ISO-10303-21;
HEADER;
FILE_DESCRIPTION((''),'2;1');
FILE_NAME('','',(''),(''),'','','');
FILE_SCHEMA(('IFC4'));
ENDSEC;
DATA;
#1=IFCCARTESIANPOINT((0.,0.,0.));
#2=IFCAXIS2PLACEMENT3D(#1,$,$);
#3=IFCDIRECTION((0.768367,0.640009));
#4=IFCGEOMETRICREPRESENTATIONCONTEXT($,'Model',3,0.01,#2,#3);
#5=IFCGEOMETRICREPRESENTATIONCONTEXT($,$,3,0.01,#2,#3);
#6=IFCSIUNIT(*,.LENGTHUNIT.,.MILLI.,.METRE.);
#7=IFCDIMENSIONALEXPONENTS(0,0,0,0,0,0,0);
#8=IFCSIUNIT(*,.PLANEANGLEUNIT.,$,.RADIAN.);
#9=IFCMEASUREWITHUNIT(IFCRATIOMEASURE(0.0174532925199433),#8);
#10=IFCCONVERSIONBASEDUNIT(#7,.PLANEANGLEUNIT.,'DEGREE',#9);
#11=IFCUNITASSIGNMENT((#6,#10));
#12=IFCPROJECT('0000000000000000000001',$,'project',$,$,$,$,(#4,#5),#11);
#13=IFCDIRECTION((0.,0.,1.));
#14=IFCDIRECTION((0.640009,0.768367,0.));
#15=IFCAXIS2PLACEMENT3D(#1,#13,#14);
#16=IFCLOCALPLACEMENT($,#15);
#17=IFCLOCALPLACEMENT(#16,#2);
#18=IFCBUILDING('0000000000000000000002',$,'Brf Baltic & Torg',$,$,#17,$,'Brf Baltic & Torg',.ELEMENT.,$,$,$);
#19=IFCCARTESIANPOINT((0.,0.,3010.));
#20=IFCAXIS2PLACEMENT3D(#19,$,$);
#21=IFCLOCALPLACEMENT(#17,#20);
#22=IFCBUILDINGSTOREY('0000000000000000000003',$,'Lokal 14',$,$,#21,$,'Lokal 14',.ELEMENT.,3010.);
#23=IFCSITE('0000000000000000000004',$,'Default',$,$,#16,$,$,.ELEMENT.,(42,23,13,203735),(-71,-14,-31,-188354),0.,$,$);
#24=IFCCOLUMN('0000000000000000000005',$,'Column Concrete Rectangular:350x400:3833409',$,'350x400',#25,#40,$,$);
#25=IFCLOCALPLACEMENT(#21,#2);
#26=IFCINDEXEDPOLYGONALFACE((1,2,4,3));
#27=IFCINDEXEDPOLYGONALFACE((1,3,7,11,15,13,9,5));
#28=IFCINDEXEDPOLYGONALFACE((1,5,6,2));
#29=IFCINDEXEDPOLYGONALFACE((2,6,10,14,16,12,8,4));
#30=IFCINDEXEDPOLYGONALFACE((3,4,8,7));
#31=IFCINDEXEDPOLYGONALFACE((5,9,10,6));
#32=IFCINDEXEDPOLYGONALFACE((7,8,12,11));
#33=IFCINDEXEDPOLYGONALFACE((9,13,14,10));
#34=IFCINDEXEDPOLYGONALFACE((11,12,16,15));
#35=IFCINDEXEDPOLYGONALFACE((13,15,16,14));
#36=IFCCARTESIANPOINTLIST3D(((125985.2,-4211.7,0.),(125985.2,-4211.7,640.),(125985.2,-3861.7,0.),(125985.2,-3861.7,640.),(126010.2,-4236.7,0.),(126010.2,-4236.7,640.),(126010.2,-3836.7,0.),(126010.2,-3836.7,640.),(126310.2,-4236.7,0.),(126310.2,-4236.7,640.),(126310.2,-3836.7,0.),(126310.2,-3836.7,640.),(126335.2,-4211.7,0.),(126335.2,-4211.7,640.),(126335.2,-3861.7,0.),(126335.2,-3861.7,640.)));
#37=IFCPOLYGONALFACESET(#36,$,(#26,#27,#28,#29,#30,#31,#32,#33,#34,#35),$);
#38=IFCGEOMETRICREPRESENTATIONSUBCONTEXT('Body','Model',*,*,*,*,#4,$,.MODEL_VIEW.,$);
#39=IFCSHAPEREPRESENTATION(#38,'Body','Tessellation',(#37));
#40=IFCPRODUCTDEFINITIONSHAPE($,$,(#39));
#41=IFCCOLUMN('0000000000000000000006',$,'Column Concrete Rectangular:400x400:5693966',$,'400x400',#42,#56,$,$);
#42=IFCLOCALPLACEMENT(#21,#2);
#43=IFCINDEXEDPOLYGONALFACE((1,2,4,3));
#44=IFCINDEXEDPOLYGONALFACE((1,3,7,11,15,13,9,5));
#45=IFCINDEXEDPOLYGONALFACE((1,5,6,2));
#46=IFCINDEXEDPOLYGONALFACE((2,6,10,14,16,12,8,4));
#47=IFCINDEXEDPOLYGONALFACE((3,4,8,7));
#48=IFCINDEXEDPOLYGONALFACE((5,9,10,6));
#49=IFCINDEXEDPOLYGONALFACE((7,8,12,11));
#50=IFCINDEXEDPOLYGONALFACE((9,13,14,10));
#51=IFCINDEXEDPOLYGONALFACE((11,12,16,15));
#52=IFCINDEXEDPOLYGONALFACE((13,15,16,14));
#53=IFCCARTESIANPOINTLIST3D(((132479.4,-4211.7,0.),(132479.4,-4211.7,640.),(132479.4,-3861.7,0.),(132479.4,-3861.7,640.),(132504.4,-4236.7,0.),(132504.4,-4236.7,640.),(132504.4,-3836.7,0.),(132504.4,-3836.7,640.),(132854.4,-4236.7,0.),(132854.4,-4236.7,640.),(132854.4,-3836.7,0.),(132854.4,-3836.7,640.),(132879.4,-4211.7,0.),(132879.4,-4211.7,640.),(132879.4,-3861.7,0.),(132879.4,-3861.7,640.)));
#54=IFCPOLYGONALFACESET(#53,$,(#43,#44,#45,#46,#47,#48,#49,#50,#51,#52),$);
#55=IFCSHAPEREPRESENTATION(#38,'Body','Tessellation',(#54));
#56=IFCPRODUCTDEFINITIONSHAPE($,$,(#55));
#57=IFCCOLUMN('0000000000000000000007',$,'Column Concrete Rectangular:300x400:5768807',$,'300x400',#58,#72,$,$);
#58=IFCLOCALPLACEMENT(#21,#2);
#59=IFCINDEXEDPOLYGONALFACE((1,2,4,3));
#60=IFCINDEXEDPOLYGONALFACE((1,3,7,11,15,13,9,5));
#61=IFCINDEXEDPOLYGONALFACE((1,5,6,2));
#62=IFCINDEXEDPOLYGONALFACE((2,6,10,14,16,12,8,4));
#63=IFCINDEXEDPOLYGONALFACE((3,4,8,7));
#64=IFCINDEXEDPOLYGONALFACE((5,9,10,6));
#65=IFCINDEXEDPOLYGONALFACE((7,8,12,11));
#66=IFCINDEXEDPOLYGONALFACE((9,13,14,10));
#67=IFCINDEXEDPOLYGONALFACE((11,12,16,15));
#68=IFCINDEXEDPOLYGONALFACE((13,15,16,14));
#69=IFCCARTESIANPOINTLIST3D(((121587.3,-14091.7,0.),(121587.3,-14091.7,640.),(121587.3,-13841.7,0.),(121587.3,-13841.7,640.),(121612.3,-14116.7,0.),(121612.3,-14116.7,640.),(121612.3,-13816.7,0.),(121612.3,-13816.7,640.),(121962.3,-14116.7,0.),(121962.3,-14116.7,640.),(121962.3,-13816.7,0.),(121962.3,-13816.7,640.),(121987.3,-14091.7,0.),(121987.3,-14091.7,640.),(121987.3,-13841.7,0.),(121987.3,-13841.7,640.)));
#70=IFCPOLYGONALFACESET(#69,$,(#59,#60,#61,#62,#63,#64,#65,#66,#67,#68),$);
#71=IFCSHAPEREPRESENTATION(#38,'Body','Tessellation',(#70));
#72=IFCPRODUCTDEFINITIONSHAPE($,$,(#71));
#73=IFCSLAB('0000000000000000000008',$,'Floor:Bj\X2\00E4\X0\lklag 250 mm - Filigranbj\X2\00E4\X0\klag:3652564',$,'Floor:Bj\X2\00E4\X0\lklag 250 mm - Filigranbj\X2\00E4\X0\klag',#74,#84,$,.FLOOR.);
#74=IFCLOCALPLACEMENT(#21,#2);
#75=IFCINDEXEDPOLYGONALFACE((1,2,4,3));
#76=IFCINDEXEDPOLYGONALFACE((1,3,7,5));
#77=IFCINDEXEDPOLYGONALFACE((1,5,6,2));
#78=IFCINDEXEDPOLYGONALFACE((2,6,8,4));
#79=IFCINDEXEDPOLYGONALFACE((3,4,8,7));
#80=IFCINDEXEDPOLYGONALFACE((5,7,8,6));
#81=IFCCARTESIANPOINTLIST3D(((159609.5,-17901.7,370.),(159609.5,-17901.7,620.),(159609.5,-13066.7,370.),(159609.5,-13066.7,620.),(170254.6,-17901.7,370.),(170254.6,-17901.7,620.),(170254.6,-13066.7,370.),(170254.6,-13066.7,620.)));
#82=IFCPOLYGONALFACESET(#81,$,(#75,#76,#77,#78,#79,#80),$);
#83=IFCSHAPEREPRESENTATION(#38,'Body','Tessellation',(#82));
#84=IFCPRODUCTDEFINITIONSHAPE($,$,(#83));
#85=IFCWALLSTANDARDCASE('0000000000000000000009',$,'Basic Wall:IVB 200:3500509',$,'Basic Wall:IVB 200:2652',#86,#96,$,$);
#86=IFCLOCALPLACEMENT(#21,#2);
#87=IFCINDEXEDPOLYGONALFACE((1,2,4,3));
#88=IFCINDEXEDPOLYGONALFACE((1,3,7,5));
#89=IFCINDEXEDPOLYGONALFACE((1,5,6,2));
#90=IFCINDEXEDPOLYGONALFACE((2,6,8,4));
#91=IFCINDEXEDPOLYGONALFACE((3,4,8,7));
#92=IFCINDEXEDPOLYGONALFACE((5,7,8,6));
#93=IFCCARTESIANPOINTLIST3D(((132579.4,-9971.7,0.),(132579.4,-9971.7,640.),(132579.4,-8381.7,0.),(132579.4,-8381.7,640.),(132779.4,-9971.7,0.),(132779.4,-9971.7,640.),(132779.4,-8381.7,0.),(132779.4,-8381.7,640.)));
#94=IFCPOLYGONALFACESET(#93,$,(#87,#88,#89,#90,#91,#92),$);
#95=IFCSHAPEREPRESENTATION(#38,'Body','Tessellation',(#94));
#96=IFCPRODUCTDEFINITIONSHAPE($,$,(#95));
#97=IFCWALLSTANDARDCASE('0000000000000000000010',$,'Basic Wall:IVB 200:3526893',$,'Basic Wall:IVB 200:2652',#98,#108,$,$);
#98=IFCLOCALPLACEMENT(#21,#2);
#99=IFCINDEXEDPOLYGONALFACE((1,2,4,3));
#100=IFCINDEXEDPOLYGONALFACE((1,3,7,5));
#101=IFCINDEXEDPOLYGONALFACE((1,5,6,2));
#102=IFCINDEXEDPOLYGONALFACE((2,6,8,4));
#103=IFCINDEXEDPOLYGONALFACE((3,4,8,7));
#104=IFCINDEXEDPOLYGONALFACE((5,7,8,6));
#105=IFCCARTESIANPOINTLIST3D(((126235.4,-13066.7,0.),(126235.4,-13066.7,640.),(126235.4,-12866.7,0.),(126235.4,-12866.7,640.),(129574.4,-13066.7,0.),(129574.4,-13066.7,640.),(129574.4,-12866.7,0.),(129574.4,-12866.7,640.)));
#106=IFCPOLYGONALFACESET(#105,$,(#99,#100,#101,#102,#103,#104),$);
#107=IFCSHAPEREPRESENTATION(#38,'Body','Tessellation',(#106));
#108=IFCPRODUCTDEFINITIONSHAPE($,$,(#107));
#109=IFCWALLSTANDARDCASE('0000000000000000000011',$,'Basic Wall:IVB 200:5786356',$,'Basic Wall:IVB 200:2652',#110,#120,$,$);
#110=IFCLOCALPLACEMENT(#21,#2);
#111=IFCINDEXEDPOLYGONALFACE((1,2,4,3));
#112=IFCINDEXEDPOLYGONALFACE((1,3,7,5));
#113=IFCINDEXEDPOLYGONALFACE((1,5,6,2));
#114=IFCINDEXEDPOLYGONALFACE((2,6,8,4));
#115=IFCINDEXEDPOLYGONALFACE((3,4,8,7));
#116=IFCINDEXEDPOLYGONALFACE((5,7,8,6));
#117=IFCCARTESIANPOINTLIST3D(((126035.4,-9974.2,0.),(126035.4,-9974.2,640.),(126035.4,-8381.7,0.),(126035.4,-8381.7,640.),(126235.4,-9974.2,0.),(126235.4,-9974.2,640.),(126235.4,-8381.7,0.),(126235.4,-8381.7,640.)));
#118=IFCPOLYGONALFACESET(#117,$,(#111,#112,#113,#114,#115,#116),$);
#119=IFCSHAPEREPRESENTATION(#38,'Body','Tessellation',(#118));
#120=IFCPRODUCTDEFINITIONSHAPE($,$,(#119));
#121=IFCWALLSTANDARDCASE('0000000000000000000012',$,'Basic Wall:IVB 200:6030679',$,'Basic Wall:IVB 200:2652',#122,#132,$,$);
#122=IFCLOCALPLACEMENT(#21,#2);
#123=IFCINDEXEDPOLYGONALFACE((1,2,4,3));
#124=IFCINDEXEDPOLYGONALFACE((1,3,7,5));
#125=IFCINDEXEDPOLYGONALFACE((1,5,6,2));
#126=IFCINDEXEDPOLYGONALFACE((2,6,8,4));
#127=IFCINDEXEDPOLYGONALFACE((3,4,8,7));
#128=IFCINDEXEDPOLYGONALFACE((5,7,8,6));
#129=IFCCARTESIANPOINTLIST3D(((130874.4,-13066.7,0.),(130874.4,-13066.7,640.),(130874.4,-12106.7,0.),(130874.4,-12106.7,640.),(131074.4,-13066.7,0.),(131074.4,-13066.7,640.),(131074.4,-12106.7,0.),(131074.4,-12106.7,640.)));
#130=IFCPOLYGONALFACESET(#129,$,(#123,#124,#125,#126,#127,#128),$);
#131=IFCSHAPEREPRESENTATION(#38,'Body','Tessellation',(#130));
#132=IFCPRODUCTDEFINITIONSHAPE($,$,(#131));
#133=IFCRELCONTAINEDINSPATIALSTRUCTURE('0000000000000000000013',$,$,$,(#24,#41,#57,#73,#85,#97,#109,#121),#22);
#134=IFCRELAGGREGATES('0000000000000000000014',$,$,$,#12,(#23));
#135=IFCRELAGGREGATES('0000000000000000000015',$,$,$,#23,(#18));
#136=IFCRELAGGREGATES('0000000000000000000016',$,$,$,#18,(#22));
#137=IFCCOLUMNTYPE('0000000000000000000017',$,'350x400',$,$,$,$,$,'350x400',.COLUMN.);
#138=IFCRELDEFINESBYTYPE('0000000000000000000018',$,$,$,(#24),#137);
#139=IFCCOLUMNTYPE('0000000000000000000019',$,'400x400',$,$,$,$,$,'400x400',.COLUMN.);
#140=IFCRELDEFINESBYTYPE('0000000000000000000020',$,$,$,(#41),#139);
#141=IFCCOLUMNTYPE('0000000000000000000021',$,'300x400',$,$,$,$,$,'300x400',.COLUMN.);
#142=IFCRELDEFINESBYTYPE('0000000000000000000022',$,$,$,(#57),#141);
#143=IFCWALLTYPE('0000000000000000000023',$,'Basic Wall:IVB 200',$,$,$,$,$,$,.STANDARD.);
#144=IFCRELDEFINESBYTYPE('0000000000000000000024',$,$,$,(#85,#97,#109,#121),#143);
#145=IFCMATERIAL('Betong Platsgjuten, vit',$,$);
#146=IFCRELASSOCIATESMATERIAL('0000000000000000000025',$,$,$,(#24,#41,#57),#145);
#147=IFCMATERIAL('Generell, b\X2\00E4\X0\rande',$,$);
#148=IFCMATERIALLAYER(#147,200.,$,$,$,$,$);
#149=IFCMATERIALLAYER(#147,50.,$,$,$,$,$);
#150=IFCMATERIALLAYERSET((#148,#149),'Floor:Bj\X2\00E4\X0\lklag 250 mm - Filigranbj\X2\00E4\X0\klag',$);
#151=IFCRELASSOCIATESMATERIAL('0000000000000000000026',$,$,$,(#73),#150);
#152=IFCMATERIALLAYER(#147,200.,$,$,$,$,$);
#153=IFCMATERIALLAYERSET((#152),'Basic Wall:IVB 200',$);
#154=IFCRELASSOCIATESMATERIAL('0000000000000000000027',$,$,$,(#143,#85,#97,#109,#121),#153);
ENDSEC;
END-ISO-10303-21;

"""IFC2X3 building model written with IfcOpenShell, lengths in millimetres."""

from ifc_helpers import new_model, entity, si_unit, converted_unit, direction, frame, frame_2d, origin, place, context, subcontext, project, spatial, polyline, rectangle, outline, extrude, clip, halfspace, source, transform, mapped, material, layer, layer_set, layer_usage, type_object, type_shapes, element, save


model = new_model("IFC2X3")

# Units and contexts
model_context = context("Model", 3, precision=0.01, world=origin(), true_north=direction((0.768367, 0.640009)))
context_of_model = context(None, 3, precision=0.01, world=origin(), true_north=direction((0.768367, 0.640009)))
body_context = subcontext(model_context, "Body", "Model", "MODEL_VIEW")
ifc_project = project(units=[si_unit("LENGTHUNIT", "METRE", prefix="MILLI"), converted_unit("PLANEANGLEUNIT", "DEGREE", entity("IfcRatioMeasure", 0.0174532925199433), si_unit("PLANEANGLEUNIT", "RADIAN"), dimensions=[0, 0, 0, 0, 0, 0, 0])], contexts=[model_context, context_of_model])

# Site, building, storey
site_placement = place(None, frame((0.0, 0.0, 0.0), z_axis=(0.0, 0.0, 1.0), x_axis=(0.640009, 0.768367, 0.0)))
site = spatial("IfcSite", under=ifc_project, at=site_placement, Name="Default", CompositionType="ELEMENT", RefLatitude=(42, 23, 13, 203735), RefLongitude=(-71, -14, -31, -188354), RefElevation=0.0)
building_placement = place(site_placement, origin())
building = spatial("IfcBuilding", under=site, at=building_placement, Name="Brf Baltic & Torg", LongName="Brf Baltic & Torg", CompositionType="ELEMENT")
storey_placement = place(building_placement, frame((0.0, 0.0, 3010.0)))
storey = spatial("IfcBuildingStorey", under=building, at=storey_placement, Name="Lokal 14", LongName="Lokal 14", CompositionType="ELEMENT", Elevation=3010.0)

# Columns
ifc_material_1 = material(Name="Betong Platsgjuten, vit")
column_type_1 = type_object("IfcColumnType", Name="350x400", ElementType="350x400", PredefinedType="COLUMN")
shared_shape_1 = source(origin(), body_context, "Body", "SweptSolid", [
    extrude(outline(polyline([(-175.0, -175.0), (175.0, -175.0), (200.0, -150.0), (200.0, 150.0), (175.0, 175.0), (-175.0, 175.0), (-200.0, 150.0), (-200.0, -150.0), (-175.0, -175.0)])), frame((0.0, 0.0, 3010.0), z_axis=(0.0, 0.0, 1.0), x_axis=(0.0, -1.0, 0.0)), (0.0, 0.0, 1.0), 640.0),
])
type_shapes(column_type_1, [shared_shape_1])
column_1_placement = place(storey_placement, frame((126160.2, -4036.7, -3010.0)))
element("IfcColumn", 1, at=column_1_placement, inside=storey, type_object=column_type_1, material=ifc_material_1, Name="Column Concrete Rectangular:350x400:3833409", ObjectType="350x400", context=body_context, shape_type="MappedRepresentation", body=[
    mapped(shared_shape_1, transform((0.0, 0.0, 0.0), scale=1.0)),
])
column_type_2 = type_object("IfcColumnType", Name="400x400", ElementType="400x400", PredefinedType="COLUMN")
shared_shape_2 = source(origin(), body_context, "Body", "SweptSolid", [
    extrude(outline(polyline([(-175.0, -200.0), (175.0, -200.0), (200.0, -175.0), (200.0, 175.0), (175.0, 200.0), (-175.0, 200.0), (-200.0, 175.0), (-200.0, -175.0), (-175.0, -200.0)])), frame((0.0, 0.0, 3010.0), z_axis=(0.0, 0.0, 1.0), x_axis=(0.0, -1.0, 0.0)), (0.0, 0.0, 1.0), 640.0),
])
type_shapes(column_type_2, [shared_shape_2])
column_2_placement = place(storey_placement, frame((132679.4, -4036.7, -3010.0)))
element("IfcColumn", 2, at=column_2_placement, inside=storey, type_object=column_type_2, material=ifc_material_1, Name="Column Concrete Rectangular:400x400:5693966", ObjectType="400x400", context=body_context, shape_type="MappedRepresentation", body=[
    mapped(shared_shape_2, transform((0.0, 0.0, 0.0), scale=1.0)),
])
column_type_3 = type_object("IfcColumnType", Name="300x400", ElementType="300x400", PredefinedType="COLUMN")
shared_shape_3 = source(origin(), body_context, "Body", "SweptSolid", [
    extrude(outline(polyline([(-175.0, -150.0), (175.0, -150.0), (200.0, -125.0), (200.0, 125.0), (175.0, 150.0), (-175.0, 150.0), (-200.0, 125.0), (-200.0, -125.0), (-175.0, -150.0)])), frame((0.0, 0.0, 3010.0), z_axis=(0.0, 0.0, 1.0), x_axis=(0.0, -1.0, 0.0)), (0.0, 0.0, 1.0), 640.0),
])
type_shapes(column_type_3, [shared_shape_3])
column_3_placement = place(storey_placement, frame((121787.3, -13966.7, -3010.0), z_axis=(0.0, 0.0, 1.0), x_axis=(0.0, 1.0, 0.0)))
element("IfcColumn", 3, at=column_3_placement, inside=storey, type_object=column_type_3, material=ifc_material_1, Name="Column Concrete Rectangular:300x400:5768807", ObjectType="300x400", context=body_context, shape_type="MappedRepresentation", body=[
    mapped(shared_shape_3, transform((0.0, 0.0, 0.0), scale=1.0)),
])

# Slab
ifc_material_2 = material(Name="Generell, bärande")
ifc_layer_1 = layer(ifc_material_2, 200.0)
ifc_layer_2 = layer(ifc_material_2, 50.0)
ifc_layer_set_1 = layer_set([ifc_layer_1, ifc_layer_2], Name="Floor:Bjälklag 250 mm - Filigranbjäklag")
ifc_layer_usage_1 = layer_usage(ifc_layer_set_1, "AXIS3", "POSITIVE", 0.0)
slab_1_placement = place(storey_placement, origin())
element("IfcSlab", 4, at=slab_1_placement, inside=storey, material=ifc_layer_usage_1, Name="Floor:Bjälklag 250 mm - Filigranbjäklag:3652564", ObjectType="Floor:Bjälklag 250 mm - Filigranbjäklag", PredefinedType="FLOOR", context=body_context, shape_type="SweptSolid", body=[
    extrude(rectangle(XDim=4835.0, YDim=10645.0, at=frame_2d((0.0, 0.0), x_axis=(1.0, 0.0))), frame((164932.0, -15484.2, 620.0), z_axis=(0.0, 0.0, -1.0), x_axis=(0.0, 1.0, 0.0)), (0.0, 0.0, 1.0), 250.0),
])

# Shared definitions
ifc_layer_3 = layer(ifc_material_2, 200.0)
ifc_layer_set_2 = layer_set([ifc_layer_3], Name="Basic Wall:IVB 200")
wall_type = type_object("IfcWallType", Name="Basic Wall:IVB 200", PredefinedType="STANDARD", material=ifc_layer_set_2)

# Walls
ifc_layer_usage_2 = layer_usage(ifc_layer_set_2, "AXIS2", "NEGATIVE", 100.0)
wall_1_placement = place(storey_placement, frame((132679.4, -9971.7, 0.0), z_axis=(0.0, 0.0, 1.0), x_axis=(0.0, 1.0, 0.0)))
element("IfcWallStandardCase", 5, at=wall_1_placement, inside=storey, type_object=wall_type, material=ifc_layer_usage_2, Name="Basic Wall:IVB 200:3500509", ObjectType="Basic Wall:IVB 200:2652", context=body_context, shape_type="Clipping", body=[
    clip(extrude(rectangle(XDim=1590.0, YDim=200.0, at=frame_2d((795.0, 0.0), x_axis=(-1.0, 0.0))), origin(), (0.0, 0.0, 1.0), 640.0), halfspace(frame((0.0, 0.0, -1360.0)), True)),
])
ifc_layer_usage_3 = layer_usage(ifc_layer_set_2, "AXIS2", "NEGATIVE", 100.0)
wall_2_placement = place(storey_placement, frame((129574.4, -12966.7, 0.0), z_axis=(0.0, 0.0, 1.0), x_axis=(-1.0, 0.0, 0.0)))
element("IfcWallStandardCase", 6, at=wall_2_placement, inside=storey, type_object=wall_type, material=ifc_layer_usage_3, Name="Basic Wall:IVB 200:3526893", ObjectType="Basic Wall:IVB 200:2652", context=body_context, shape_type="Clipping", body=[
    clip(extrude(rectangle(XDim=3339.0, YDim=200.0, at=frame_2d((1669.5, 0.0), x_axis=(-1.0, 0.0))), origin(), (0.0, 0.0, 1.0), 640.0), halfspace(frame((0.0, 0.0, -1360.0)), True)),
])

# Walls
ifc_layer_usage_4 = layer_usage(ifc_layer_set_2, "AXIS2", "NEGATIVE", 100.0)
wall_3_placement = place(storey_placement, frame((126135.4, -9974.2, 0.0), z_axis=(0.0, 0.0, 1.0), x_axis=(0.0, 1.0, 0.0)))
element("IfcWallStandardCase", 7, at=wall_3_placement, inside=storey, type_object=wall_type, material=ifc_layer_usage_4, Name="Basic Wall:IVB 200:5786356", ObjectType="Basic Wall:IVB 200:2652", context=body_context, shape_type="Clipping", body=[
    clip(extrude(rectangle(XDim=1592.5, YDim=200.0, at=frame_2d((796.3, 0.0), x_axis=(-1.0, 0.0))), origin(), (0.0, 0.0, 1.0), 640.0), halfspace(frame((0.0, 0.0, -1360.0)), True)),
])
ifc_layer_usage_5 = layer_usage(ifc_layer_set_2, "AXIS2", "POSITIVE", -100.0)
wall_4_placement = place(storey_placement, frame((130974.4, -13066.7, 0.0), z_axis=(0.0, 0.0, 1.0), x_axis=(0.0, 1.0, 0.0)))
element("IfcWallStandardCase", 8, at=wall_4_placement, inside=storey, type_object=wall_type, material=ifc_layer_usage_5, Name="Basic Wall:IVB 200:6030679", ObjectType="Basic Wall:IVB 200:2652", context=body_context, shape_type="Clipping", body=[
    clip(extrude(rectangle(XDim=960.0, YDim=200.0, at=frame_2d((480.0, 0.0), x_axis=(-1.0, 0.0))), origin(), (0.0, 0.0, 1.0), 640.0), halfspace(frame((0.0, 0.0, -1360.0)), True)),
])

save(model, "model.ifc")
